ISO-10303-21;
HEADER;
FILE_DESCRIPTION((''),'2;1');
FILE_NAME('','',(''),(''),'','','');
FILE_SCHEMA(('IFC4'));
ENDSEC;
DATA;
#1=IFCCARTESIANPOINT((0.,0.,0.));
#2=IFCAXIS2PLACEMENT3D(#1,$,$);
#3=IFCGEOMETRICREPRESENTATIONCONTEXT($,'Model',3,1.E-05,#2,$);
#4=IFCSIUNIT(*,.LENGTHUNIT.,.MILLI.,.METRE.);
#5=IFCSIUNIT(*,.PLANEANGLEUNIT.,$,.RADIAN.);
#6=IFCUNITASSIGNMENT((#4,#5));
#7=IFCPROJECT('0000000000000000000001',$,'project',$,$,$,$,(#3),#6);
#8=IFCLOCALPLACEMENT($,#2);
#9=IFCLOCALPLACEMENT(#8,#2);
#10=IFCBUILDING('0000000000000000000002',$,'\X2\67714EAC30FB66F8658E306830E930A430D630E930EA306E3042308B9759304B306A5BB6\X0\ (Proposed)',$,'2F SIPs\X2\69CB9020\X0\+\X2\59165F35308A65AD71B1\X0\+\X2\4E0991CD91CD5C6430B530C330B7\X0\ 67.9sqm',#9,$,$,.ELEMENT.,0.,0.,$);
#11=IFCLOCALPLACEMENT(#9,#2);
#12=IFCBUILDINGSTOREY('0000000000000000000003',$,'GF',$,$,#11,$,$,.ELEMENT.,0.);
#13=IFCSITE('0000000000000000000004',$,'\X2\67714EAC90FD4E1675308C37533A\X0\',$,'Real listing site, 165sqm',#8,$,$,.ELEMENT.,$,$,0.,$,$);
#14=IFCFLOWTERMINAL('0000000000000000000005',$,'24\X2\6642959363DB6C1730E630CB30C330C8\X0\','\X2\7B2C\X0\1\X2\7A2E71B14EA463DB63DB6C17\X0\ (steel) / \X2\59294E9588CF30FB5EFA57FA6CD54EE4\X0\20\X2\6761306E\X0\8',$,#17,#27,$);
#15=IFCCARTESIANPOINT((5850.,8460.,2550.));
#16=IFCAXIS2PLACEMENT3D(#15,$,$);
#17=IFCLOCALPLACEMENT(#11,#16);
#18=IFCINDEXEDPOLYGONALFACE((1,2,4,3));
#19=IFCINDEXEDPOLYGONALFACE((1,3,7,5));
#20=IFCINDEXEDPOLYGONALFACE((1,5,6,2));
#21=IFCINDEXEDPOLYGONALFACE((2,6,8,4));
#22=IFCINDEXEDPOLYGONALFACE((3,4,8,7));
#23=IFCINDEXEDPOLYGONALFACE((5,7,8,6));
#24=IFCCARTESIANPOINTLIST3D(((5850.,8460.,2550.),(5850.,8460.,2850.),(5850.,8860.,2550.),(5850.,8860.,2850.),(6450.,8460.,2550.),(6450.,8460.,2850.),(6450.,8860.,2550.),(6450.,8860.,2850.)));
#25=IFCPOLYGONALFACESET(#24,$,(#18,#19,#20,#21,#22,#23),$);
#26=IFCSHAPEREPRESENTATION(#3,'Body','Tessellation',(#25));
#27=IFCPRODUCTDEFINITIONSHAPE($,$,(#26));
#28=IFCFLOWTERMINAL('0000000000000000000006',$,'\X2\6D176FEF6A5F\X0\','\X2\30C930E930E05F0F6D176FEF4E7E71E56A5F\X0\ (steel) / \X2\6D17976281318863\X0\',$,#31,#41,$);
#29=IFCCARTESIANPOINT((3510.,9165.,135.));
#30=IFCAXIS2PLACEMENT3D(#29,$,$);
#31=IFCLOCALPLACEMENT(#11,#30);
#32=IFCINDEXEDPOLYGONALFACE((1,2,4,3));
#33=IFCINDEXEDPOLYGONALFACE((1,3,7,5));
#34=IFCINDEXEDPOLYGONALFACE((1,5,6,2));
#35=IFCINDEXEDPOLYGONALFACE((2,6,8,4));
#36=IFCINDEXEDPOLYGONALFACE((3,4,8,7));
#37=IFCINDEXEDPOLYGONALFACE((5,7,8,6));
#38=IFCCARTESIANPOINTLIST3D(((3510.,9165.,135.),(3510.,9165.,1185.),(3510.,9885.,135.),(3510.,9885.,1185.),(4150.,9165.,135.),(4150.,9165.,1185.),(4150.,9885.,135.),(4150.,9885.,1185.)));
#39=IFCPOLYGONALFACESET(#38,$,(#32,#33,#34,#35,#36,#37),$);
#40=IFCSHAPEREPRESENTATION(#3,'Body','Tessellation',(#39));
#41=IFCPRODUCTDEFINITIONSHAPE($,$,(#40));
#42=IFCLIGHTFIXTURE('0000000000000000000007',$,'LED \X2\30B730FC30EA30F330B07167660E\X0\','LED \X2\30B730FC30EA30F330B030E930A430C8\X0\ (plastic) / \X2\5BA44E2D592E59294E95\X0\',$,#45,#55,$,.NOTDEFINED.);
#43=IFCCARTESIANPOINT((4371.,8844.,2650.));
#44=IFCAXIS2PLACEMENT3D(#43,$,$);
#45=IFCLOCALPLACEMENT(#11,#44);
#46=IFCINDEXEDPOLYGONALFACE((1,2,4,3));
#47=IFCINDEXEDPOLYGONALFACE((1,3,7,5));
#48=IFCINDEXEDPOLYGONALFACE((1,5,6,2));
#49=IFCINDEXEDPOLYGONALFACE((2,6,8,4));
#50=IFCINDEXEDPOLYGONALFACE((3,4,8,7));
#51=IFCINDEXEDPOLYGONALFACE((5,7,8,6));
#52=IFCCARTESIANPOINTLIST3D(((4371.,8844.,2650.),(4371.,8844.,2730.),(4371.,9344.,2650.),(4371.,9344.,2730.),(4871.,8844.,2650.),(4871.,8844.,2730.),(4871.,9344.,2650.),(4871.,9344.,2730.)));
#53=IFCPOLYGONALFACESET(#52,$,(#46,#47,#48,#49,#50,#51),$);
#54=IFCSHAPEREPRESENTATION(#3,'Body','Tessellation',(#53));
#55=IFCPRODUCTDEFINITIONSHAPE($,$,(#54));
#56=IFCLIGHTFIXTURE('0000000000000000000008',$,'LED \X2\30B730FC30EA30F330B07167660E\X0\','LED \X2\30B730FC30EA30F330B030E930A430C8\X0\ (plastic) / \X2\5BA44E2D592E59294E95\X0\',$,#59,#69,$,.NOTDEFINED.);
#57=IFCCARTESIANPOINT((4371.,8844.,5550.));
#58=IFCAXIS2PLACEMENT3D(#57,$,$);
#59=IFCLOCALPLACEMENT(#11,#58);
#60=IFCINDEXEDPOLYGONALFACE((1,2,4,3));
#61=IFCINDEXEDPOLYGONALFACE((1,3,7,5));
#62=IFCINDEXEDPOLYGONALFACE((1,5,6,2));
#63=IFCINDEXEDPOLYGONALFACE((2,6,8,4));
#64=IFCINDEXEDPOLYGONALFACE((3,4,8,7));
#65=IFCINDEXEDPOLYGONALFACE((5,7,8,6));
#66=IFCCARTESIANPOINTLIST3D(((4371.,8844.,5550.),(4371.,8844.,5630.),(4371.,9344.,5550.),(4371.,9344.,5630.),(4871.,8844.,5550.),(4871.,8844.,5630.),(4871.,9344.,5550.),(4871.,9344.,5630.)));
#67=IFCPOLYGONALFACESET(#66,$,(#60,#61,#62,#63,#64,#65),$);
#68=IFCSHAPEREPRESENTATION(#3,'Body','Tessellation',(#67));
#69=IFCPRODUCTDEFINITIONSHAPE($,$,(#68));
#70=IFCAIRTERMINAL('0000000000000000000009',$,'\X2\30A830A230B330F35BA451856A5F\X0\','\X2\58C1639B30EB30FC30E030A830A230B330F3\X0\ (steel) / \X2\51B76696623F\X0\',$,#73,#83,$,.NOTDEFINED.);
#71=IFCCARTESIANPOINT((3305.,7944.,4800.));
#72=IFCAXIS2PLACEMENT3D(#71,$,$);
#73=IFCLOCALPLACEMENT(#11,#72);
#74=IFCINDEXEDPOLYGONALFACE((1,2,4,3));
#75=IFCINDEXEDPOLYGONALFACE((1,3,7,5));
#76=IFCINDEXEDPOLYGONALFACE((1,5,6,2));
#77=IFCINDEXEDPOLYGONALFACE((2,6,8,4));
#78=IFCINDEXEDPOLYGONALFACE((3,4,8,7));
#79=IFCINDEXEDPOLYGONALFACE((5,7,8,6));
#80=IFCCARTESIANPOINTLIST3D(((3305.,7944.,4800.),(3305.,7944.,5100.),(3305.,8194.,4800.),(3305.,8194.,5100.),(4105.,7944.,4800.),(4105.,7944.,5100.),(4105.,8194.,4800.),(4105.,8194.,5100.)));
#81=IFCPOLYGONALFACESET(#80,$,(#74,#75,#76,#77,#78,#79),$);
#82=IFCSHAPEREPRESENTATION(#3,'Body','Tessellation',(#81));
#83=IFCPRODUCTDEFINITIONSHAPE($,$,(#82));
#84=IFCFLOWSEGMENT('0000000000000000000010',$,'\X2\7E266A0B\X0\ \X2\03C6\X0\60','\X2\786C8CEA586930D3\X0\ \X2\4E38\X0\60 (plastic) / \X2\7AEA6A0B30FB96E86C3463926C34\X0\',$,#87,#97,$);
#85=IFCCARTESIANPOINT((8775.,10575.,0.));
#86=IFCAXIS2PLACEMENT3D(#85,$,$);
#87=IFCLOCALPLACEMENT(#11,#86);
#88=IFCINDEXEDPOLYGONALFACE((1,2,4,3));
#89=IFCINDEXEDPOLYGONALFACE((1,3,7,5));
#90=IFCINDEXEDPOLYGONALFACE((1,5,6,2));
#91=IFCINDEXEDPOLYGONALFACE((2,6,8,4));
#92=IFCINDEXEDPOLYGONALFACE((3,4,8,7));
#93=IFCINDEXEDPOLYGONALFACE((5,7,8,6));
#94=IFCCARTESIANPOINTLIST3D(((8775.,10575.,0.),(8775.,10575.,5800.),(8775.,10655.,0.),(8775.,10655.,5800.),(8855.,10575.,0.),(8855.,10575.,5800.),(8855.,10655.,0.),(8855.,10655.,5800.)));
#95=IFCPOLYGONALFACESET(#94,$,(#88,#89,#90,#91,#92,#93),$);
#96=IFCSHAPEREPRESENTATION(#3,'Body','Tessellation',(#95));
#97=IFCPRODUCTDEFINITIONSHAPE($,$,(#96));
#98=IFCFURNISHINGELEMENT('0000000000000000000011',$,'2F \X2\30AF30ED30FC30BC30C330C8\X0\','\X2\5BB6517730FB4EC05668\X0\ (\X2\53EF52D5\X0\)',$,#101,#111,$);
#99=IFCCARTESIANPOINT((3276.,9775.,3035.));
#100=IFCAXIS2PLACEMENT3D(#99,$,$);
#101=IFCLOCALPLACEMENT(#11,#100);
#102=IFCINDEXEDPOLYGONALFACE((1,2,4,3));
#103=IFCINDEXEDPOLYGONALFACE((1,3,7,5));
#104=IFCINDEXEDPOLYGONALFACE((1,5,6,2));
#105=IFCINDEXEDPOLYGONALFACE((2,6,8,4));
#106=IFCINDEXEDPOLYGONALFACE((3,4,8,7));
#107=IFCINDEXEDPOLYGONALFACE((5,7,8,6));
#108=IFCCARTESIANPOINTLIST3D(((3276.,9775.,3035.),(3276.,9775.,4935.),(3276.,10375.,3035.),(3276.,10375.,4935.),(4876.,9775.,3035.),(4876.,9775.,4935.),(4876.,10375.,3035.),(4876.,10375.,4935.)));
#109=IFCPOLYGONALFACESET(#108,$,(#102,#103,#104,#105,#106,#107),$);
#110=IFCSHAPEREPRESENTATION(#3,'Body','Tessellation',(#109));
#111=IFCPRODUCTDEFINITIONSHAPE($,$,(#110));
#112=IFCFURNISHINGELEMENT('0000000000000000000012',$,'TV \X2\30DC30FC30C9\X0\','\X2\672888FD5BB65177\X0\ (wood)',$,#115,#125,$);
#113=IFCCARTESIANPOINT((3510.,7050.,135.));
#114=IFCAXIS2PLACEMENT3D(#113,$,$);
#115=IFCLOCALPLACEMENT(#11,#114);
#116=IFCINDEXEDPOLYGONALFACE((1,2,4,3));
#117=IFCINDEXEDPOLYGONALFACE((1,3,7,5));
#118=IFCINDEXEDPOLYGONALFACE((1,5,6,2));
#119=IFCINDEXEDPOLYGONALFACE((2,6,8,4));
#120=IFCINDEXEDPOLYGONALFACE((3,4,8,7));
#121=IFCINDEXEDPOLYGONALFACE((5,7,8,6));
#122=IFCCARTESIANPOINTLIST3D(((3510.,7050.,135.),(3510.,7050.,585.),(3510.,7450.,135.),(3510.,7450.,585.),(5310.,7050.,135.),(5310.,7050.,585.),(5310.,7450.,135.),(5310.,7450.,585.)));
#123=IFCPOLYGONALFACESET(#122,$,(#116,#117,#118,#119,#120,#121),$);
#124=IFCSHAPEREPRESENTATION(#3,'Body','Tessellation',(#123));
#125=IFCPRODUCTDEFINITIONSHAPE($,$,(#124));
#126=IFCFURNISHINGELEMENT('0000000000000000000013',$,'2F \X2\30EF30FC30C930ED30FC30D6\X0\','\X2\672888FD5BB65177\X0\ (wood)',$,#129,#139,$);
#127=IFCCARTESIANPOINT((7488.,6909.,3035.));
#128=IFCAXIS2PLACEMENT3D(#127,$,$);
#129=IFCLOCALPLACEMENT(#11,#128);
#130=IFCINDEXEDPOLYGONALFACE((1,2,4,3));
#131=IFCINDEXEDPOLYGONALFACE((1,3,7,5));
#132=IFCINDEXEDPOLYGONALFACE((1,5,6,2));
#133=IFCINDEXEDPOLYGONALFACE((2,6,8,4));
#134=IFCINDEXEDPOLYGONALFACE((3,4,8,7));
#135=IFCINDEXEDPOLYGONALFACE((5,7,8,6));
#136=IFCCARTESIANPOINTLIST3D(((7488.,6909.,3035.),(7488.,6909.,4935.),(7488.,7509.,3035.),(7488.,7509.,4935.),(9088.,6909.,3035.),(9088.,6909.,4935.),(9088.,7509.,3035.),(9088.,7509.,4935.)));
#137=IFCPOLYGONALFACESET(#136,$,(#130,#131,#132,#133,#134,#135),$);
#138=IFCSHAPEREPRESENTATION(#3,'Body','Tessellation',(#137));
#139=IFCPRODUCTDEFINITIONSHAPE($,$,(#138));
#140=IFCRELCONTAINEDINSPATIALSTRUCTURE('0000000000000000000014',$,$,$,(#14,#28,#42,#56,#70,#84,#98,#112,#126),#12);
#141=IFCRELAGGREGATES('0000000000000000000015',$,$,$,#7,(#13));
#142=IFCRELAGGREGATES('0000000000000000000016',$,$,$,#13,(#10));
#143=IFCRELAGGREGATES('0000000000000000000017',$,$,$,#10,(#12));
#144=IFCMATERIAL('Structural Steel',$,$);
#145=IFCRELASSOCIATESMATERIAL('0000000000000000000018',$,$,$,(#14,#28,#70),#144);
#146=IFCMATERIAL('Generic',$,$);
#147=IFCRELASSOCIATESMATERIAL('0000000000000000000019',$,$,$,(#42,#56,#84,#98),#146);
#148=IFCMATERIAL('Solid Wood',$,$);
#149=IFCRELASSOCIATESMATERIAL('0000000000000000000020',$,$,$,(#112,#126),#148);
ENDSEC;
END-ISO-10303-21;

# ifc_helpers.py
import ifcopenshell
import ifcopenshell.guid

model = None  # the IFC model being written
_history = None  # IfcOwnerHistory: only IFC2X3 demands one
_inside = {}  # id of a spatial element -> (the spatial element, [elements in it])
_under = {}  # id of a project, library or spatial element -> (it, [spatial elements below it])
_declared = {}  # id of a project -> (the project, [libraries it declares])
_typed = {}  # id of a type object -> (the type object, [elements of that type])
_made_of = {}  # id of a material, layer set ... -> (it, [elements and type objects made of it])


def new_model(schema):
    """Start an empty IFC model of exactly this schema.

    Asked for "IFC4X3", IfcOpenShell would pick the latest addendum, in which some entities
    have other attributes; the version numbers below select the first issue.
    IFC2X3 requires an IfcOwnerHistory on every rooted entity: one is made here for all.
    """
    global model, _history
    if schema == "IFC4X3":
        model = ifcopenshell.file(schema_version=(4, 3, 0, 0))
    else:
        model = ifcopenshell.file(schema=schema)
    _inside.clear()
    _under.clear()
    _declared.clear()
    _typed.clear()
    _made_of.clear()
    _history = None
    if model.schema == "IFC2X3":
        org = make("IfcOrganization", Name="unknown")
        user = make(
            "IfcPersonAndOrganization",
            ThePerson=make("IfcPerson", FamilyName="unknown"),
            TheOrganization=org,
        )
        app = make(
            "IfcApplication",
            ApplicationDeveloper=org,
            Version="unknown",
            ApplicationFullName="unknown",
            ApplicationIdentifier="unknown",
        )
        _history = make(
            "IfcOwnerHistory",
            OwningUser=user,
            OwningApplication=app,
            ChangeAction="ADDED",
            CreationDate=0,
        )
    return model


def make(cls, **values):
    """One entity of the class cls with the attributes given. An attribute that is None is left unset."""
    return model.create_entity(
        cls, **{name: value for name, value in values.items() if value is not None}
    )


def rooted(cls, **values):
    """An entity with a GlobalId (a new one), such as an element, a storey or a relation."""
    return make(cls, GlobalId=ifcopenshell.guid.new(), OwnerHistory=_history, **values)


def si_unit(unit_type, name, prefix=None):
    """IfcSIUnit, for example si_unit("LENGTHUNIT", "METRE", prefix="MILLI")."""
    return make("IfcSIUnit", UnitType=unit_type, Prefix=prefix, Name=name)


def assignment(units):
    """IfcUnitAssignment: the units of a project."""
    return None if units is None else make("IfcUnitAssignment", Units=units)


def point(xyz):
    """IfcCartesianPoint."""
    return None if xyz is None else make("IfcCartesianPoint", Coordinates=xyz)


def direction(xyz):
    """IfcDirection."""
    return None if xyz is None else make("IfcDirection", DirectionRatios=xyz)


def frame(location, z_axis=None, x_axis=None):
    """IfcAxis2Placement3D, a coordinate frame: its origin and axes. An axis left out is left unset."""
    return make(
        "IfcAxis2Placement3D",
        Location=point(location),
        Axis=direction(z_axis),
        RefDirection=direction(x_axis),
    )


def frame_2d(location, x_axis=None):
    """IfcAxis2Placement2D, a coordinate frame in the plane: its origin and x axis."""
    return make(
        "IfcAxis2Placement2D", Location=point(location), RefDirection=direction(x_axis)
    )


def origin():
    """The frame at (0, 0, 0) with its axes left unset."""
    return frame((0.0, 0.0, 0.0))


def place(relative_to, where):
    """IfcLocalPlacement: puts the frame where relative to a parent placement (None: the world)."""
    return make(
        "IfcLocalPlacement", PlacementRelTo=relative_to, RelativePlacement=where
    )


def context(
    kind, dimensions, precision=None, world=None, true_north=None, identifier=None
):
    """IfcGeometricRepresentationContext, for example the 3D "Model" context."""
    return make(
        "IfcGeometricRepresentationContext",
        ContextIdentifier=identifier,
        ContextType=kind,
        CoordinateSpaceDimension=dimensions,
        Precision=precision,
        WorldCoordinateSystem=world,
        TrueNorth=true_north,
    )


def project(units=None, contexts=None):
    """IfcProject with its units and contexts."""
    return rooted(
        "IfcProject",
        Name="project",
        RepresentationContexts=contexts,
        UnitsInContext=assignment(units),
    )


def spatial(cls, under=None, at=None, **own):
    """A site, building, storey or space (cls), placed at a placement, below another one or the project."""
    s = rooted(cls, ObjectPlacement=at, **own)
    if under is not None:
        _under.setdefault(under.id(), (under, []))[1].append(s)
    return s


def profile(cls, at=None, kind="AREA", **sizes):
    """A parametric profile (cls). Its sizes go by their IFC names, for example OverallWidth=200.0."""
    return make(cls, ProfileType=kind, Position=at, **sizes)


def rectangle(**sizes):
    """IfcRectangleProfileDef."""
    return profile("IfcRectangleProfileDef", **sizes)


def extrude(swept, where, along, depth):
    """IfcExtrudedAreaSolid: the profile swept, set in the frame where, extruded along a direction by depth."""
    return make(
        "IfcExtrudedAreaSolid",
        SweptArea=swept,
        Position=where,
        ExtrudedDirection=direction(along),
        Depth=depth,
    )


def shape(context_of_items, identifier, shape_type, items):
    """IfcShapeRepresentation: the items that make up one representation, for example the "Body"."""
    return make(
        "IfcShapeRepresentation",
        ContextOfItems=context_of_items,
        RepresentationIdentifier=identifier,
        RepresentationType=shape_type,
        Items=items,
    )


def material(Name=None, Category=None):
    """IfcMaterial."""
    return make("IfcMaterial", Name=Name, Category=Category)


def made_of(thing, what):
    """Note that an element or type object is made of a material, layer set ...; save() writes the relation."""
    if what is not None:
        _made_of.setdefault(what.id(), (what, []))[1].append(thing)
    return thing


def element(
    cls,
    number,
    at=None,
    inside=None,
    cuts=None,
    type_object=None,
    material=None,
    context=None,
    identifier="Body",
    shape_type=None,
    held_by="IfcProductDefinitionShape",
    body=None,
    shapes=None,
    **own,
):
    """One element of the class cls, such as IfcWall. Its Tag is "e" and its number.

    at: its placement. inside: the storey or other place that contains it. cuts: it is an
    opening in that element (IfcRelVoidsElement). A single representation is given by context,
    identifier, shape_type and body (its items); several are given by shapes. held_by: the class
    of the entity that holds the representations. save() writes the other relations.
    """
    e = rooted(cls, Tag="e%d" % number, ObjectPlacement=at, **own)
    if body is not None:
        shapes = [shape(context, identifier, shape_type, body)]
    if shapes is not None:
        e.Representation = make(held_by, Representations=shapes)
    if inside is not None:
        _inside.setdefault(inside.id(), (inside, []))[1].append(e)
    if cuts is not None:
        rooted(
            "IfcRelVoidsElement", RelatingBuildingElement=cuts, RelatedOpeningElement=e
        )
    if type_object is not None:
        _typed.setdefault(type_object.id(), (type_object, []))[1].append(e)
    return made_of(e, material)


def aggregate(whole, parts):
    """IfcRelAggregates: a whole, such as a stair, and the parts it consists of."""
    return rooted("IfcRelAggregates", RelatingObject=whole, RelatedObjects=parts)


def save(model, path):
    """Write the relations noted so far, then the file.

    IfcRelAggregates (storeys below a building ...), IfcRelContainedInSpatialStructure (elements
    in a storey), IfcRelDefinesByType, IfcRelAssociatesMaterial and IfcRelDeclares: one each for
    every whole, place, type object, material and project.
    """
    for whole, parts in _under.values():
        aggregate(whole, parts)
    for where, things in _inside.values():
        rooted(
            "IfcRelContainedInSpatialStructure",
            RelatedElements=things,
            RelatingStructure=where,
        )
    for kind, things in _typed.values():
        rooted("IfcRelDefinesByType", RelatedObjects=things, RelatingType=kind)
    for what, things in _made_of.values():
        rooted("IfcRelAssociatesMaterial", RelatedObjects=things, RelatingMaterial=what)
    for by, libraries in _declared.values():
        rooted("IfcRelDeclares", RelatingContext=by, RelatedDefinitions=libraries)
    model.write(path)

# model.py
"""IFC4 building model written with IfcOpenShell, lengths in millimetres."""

from ifc_helpers import new_model, si_unit, frame, frame_2d, origin, place, context, project, spatial, rectangle, extrude, material, element, save


model = new_model("IFC4")

# Units and contexts
model_context = context("Model", 3, precision=1e-05, world=origin())
ifc_project = project(units=[si_unit("LENGTHUNIT", "METRE", prefix="MILLI"), si_unit("PLANEANGLEUNIT", "RADIAN")], contexts=[model_context])

# Site, building, storey
site_placement = place(None, origin())
site = spatial("IfcSite", under=ifc_project, at=site_placement, Name="東京都世田谷区", ObjectType="Real listing site, 165sqm", CompositionType="ELEMENT", RefElevation=0.0)
building_placement = place(site_placement, origin())
building = spatial("IfcBuilding", under=site, at=building_placement, Name="東京・書斎とライブラリのある静かな家 (Proposed)", ObjectType="2F SIPs構造+外張り断熱+三重重層サッシ 67.9sqm", CompositionType="ELEMENT", ElevationOfRefHeight=0.0, ElevationOfTerrain=0.0)
storey_placement = place(building_placement, origin())
storey = spatial("IfcBuildingStorey", under=building, at=storey_placement, Name="GF", CompositionType="ELEMENT", Elevation=0.0)

# Shared definitions
ifc_material_1 = material(Name="Solid Wood")

# Shared definitions
ifc_material_2 = material(Name="Generic")

# Flow terminals
ifc_material_3 = material(Name="Structural Steel")
flow_terminal_1_placement = place(storey_placement, frame((5850.0, 8460.0, 2550.0)))
element("IfcFlowTerminal", 1, at=flow_terminal_1_placement, inside=storey, material=ifc_material_3, Name="24時間換気ユニット", Description="第1種熱交換換気 (steel) / 天井裏・建基法令20条の8", context=model_context, shape_type="SweptSolid", body=[
    extrude(rectangle(XDim=600.0, YDim=400.0, at=frame_2d((300.0, 200.0))), frame((5850.0, 8460.0, 2550.0)), (0.0, 0.0, 1.0), 300.0),
])
flow_terminal_2_placement = place(storey_placement, frame((3510.0, 9165.0, 135.0)))
element("IfcFlowTerminal", 2, at=flow_terminal_2_placement, inside=storey, material=ifc_material_3, Name="洗濯機", Description="ドラム式洗濯乾燥機 (steel) / 洗面脱衣", context=model_context, shape_type="SweptSolid", body=[
    extrude(rectangle(XDim=640.0, YDim=720.0, at=frame_2d((320.0, 360.0))), frame((3510.0, 9165.0, 135.0)), (0.0, 0.0, 1.0), 1050.0),
])

# Light fixtures
light_fixture_1_placement = place(storey_placement, frame((4371.0, 8844.0, 2650.0)))
element("IfcLightFixture", 3, at=light_fixture_1_placement, inside=storey, material=ifc_material_2, Name="LED シーリング照明", Description="LED シーリングライト (plastic) / 室中央天井", PredefinedType="NOTDEFINED", context=model_context, shape_type="SweptSolid", body=[
    extrude(rectangle(XDim=500.0, YDim=500.0, at=frame_2d((250.0, 250.0))), frame((4371.0, 8844.0, 2650.0)), (0.0, 0.0, 1.0), 80.0),
])
light_fixture_2_placement = place(storey_placement, frame((4371.0, 8844.0, 5550.0)))
element("IfcLightFixture", 4, at=light_fixture_2_placement, inside=storey, material=ifc_material_2, Name="LED シーリング照明", Description="LED シーリングライト (plastic) / 室中央天井", PredefinedType="NOTDEFINED", context=model_context, shape_type="SweptSolid", body=[
    extrude(rectangle(XDim=500.0, YDim=500.0, at=frame_2d((250.0, 250.0))), frame((4371.0, 8844.0, 5550.0)), (0.0, 0.0, 1.0), 80.0),
])

# Air terminal
air_terminal_placement = place(storey_placement, frame((3305.0, 7944.0, 4800.0)))
element("IfcAirTerminal", 5, at=air_terminal_placement, inside=storey, material=ifc_material_3, Name="エアコン室内機", Description="壁掛ルームエアコン (steel) / 冷暖房", PredefinedType="NOTDEFINED", context=model_context, shape_type="SweptSolid", body=[
    extrude(rectangle(XDim=800.0, YDim=250.0, at=frame_2d((400.0, 125.0))), frame((3305.0, 7944.0, 4800.0)), (0.0, 0.0, 1.0), 300.0),
])

# Flow segment
flow_segment_placement = place(storey_placement, frame((8775.0, 10575.0, 0.0)))
element("IfcFlowSegment", 6, at=flow_segment_placement, inside=storey, material=ifc_material_2, Name="縦樋 φ60", Description="硬質塩ビ 丸60 (plastic) / 竪樋・雨水排水", context=model_context, shape_type="SweptSolid", body=[
    extrude(rectangle(XDim=80.0, YDim=80.0, at=frame_2d((40.0, 40.0))), frame((8775.0, 10575.0, 0.0)), (0.0, 0.0, 1.0), 5800.0),
])

# Furnishing elements
furnishing_1_placement = place(storey_placement, frame((3276.0, 9775.0, 3035.0)))
element("IfcFurnishingElement", 7, at=furnishing_1_placement, inside=storey, material=ifc_material_2, Name="2F クローゼット", Description="家具・什器 (可動)", context=model_context, shape_type="SweptSolid", body=[
    extrude(rectangle(XDim=1600.0, YDim=600.0, at=frame_2d((800.0, 300.0))), frame((3276.0, 9775.0, 3035.0)), (0.0, 0.0, 1.0), 1900.0),
])
furnishing_2_placement = place(storey_placement, frame((3510.0, 7050.0, 135.0)))
element("IfcFurnishingElement", 8, at=furnishing_2_placement, inside=storey, material=ifc_material_1, Name="TV ボード", Description="木製家具 (wood)", context=model_context, shape_type="SweptSolid", body=[
    extrude(rectangle(XDim=1800.0, YDim=400.0, at=frame_2d((900.0, 200.0))), frame((3510.0, 7050.0, 135.0)), (0.0, 0.0, 1.0), 450.0),
])
furnishing_3_placement = place(storey_placement, frame((7488.0, 6909.0, 3035.0)))
element("IfcFurnishingElement", 9, at=furnishing_3_placement, inside=storey, material=ifc_material_1, Name="2F ワードローブ", Description="木製家具 (wood)", context=model_context, shape_type="SweptSolid", body=[
    extrude(rectangle(XDim=1600.0, YDim=600.0, at=frame_2d((800.0, 300.0))), frame((7488.0, 6909.0, 3035.0)), (0.0, 0.0, 1.0), 1900.0),
])

save(model, "model.ifc")
